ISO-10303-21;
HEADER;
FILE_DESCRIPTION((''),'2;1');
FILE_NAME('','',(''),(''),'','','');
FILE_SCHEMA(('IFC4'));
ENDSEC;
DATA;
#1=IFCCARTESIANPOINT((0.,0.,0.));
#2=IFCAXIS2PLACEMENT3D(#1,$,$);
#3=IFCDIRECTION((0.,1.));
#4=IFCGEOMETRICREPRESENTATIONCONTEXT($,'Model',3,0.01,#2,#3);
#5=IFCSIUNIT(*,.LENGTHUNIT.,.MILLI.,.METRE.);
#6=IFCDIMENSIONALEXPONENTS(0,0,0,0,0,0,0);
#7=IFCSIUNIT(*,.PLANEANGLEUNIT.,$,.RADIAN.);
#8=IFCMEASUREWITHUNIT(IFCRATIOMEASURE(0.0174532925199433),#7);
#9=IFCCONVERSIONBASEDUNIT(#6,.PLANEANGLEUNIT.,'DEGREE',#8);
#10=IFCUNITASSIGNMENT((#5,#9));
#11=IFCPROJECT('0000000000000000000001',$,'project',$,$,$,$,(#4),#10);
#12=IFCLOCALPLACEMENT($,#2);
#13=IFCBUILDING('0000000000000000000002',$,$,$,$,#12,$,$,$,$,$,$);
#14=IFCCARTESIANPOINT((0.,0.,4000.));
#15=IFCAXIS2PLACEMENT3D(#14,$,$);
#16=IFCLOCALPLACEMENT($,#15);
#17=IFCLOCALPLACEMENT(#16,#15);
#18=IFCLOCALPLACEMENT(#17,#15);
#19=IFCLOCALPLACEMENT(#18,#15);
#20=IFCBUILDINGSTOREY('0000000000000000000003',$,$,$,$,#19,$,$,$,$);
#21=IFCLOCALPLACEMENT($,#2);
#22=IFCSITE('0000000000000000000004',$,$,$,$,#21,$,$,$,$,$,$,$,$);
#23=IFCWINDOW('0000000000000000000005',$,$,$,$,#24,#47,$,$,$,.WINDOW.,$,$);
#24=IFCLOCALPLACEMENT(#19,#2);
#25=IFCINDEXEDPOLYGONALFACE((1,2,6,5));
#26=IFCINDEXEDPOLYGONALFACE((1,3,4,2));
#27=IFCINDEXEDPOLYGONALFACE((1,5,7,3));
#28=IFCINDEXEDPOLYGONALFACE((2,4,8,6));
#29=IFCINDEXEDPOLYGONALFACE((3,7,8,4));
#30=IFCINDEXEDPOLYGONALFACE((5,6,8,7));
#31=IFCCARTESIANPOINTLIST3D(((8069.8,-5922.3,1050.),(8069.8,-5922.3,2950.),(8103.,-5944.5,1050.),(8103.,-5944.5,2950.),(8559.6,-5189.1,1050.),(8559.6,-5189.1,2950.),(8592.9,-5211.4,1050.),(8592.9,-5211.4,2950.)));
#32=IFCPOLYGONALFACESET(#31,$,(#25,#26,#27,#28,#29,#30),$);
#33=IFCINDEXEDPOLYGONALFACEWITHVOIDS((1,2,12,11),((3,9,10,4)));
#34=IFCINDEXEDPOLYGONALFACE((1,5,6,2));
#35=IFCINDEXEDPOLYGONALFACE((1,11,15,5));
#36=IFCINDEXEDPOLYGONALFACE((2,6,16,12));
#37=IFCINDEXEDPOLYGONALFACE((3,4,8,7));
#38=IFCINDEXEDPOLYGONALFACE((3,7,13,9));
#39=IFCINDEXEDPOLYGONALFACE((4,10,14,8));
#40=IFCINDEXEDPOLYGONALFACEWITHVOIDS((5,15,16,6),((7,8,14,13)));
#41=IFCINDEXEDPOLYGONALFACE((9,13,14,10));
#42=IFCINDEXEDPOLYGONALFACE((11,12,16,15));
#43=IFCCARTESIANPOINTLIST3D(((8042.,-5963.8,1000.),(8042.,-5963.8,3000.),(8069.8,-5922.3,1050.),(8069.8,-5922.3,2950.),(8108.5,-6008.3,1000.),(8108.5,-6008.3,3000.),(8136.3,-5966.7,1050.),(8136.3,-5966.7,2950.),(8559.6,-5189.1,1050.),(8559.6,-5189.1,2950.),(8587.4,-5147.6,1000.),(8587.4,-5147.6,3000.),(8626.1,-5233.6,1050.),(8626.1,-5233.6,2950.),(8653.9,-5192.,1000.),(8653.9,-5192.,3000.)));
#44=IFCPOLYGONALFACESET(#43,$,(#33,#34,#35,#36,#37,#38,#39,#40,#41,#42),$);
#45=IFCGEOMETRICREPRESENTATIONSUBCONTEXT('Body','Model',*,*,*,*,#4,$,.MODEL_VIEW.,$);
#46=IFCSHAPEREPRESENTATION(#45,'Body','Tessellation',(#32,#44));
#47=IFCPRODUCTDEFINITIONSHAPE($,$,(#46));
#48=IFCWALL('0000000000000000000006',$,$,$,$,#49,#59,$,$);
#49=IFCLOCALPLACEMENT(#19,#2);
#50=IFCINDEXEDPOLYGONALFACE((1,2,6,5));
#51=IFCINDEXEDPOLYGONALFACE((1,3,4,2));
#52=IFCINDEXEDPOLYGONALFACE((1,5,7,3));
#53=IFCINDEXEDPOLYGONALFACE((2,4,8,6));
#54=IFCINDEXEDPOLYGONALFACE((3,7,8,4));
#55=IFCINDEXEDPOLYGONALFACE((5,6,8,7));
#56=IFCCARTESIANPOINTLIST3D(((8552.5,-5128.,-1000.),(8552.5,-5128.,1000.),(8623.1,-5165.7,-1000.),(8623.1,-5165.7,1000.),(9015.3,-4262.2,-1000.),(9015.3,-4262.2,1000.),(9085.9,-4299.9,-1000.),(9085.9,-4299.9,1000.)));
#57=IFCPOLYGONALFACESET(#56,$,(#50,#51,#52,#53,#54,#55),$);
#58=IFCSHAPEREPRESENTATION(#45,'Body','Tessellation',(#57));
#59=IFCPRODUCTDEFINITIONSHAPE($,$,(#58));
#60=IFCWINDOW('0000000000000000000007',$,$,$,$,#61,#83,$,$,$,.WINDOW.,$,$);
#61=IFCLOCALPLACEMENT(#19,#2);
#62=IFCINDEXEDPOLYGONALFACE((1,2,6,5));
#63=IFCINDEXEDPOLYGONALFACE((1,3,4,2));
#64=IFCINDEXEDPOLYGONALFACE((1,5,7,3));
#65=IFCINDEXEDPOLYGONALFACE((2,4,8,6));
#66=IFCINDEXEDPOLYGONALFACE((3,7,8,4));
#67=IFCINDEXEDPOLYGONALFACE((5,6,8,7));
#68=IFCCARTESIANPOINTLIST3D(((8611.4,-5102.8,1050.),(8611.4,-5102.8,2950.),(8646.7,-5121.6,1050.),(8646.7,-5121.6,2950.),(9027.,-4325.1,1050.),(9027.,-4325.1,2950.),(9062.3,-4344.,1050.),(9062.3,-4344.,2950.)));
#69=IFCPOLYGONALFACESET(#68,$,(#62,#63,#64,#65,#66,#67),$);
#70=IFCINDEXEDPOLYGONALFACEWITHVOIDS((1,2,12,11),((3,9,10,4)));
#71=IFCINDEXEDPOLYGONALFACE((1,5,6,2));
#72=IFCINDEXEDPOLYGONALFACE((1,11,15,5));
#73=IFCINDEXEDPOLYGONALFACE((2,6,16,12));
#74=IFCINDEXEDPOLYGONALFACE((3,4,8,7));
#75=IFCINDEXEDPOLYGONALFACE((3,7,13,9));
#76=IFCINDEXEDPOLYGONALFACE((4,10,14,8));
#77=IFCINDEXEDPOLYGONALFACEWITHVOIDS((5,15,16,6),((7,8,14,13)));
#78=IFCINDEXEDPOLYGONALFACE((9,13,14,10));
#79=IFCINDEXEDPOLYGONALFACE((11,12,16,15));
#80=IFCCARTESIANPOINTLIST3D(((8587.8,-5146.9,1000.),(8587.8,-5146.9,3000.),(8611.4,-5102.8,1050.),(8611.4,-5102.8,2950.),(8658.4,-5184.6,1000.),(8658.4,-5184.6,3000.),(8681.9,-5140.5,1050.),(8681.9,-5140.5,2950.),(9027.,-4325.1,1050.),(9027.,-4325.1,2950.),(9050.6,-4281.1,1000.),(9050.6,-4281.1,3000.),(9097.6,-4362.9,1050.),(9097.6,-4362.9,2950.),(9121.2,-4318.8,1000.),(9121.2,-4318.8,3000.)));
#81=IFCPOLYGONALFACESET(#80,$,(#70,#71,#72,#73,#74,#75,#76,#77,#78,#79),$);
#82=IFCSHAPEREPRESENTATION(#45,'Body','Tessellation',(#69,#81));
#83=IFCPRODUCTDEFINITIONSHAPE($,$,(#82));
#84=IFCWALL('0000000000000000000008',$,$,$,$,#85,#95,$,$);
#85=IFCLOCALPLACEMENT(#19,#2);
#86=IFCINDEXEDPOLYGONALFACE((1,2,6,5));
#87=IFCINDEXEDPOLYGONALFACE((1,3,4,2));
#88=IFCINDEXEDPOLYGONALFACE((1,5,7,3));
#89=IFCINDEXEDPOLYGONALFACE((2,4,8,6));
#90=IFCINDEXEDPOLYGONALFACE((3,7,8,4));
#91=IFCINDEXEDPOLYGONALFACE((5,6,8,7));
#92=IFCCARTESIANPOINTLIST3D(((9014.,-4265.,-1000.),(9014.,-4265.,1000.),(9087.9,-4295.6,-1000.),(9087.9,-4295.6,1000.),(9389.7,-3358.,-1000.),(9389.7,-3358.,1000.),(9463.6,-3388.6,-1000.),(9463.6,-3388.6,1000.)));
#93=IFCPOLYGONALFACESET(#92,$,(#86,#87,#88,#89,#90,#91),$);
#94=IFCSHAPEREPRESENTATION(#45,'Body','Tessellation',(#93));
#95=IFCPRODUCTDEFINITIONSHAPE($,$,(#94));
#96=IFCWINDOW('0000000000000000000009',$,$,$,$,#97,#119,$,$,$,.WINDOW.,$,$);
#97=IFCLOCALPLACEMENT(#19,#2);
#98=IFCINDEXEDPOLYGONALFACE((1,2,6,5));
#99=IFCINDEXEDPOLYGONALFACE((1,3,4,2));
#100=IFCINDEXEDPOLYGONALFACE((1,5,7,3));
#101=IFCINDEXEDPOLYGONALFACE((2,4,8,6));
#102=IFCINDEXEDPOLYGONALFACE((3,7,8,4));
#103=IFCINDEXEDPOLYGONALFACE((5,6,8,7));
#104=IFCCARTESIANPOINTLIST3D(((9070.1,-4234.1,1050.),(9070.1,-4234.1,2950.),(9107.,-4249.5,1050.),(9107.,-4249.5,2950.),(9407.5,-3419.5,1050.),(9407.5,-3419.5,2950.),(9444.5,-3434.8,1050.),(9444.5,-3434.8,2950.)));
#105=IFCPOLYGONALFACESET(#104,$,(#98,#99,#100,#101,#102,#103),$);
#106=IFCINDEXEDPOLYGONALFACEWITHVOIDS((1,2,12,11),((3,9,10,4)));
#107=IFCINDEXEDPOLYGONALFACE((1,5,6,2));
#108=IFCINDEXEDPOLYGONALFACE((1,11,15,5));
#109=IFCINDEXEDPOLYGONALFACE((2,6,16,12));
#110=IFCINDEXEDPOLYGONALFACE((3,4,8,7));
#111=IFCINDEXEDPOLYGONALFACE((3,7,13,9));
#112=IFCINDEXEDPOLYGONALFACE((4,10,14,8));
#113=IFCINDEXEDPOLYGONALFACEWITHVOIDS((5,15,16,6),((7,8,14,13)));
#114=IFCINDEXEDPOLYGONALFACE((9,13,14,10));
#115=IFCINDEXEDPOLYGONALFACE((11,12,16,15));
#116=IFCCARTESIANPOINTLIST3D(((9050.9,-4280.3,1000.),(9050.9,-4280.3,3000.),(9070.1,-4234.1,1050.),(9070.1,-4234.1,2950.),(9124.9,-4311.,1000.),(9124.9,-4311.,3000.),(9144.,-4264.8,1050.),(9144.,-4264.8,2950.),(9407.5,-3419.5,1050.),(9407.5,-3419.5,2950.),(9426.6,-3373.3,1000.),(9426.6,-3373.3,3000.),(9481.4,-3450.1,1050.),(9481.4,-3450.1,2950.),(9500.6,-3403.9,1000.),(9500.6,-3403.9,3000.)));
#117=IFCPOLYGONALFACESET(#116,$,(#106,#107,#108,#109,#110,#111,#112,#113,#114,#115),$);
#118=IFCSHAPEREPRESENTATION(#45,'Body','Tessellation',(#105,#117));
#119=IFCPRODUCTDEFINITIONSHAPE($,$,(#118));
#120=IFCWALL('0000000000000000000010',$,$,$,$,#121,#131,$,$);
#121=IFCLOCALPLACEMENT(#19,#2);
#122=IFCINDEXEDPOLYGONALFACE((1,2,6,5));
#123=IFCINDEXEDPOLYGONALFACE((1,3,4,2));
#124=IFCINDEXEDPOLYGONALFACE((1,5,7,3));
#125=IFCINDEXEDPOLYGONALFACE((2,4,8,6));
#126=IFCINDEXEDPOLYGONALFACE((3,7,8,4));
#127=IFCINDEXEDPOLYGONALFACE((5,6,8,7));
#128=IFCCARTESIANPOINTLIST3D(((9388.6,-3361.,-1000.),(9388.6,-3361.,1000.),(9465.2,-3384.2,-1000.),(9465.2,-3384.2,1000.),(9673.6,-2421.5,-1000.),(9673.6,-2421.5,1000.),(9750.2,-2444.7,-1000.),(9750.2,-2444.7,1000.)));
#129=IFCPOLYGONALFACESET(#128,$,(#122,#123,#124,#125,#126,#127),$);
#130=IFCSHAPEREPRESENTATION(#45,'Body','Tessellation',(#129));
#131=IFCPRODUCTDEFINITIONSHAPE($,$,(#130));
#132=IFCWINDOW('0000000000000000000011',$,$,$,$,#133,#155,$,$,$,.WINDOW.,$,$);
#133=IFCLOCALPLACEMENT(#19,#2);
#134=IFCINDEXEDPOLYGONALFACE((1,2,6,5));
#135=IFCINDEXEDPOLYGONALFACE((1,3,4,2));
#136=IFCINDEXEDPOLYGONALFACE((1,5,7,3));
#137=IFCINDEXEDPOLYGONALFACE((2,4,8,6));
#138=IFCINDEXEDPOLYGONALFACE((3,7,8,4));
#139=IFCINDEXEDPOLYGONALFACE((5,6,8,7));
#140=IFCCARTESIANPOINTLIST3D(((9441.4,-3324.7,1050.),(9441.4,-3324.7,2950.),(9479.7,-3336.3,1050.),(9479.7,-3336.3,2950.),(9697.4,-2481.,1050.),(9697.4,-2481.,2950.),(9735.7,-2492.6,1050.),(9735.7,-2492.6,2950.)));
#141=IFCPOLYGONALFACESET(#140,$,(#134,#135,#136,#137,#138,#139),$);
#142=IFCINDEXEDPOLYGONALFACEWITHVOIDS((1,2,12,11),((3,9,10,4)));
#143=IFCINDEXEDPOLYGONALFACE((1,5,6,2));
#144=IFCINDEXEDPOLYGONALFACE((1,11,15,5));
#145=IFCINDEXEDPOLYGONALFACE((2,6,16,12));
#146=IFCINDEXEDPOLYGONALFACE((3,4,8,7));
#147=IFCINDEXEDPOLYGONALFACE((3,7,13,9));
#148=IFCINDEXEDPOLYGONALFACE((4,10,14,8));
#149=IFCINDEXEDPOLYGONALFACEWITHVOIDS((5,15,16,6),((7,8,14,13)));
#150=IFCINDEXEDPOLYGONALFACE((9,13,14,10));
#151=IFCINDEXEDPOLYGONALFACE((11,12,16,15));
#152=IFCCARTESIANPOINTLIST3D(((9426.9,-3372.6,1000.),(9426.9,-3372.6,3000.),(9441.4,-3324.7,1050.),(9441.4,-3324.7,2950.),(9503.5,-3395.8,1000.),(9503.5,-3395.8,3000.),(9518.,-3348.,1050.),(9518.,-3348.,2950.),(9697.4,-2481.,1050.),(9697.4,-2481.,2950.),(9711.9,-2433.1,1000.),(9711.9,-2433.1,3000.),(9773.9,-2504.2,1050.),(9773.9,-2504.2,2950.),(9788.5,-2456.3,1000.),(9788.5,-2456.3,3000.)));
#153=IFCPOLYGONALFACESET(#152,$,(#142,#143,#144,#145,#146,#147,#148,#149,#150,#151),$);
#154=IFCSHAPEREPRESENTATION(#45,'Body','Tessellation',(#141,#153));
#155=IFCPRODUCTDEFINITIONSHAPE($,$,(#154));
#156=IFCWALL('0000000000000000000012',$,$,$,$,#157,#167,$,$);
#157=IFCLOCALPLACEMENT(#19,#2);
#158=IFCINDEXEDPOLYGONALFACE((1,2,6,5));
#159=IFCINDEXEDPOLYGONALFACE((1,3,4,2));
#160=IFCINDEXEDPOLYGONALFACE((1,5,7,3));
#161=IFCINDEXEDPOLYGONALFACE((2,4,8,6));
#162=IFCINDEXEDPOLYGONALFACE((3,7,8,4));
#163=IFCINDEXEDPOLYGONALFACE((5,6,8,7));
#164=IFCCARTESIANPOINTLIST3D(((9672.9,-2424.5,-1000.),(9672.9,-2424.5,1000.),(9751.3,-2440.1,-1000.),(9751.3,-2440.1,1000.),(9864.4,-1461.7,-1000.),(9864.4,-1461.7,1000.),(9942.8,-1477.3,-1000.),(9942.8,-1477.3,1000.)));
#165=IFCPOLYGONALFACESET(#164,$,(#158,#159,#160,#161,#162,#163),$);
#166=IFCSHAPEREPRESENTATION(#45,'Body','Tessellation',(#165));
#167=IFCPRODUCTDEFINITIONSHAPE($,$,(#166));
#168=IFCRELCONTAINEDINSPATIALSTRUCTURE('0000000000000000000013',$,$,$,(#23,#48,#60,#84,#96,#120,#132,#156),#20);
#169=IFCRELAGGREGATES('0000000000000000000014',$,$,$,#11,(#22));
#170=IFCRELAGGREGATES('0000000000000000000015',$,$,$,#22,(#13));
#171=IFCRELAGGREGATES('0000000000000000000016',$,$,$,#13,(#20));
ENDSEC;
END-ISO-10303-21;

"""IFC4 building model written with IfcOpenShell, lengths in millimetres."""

from ifc_helpers import new_model, entity, si_unit, converted_unit, direction, frame, origin, origin_2d, place, context, subcontext, project, spatial, rectangle, extrude, element, save


model = new_model("IFC4")

# Units and contexts
model_context = context("Model", 3, precision=0.01, world=origin(), true_north=direction((0.0, 1.0)))
body_context = subcontext(model_context, "Body", "Model", "MODEL_VIEW")
ifc_project = project(units=[si_unit("LENGTHUNIT", "METRE", prefix="MILLI"), converted_unit("PLANEANGLEUNIT", "DEGREE", entity("IfcRatioMeasure", 0.0174532925199433), si_unit("PLANEANGLEUNIT", "RADIAN"), dimensions=[0, 0, 0, 0, 0, 0, 0])], contexts=[model_context])

# Site, building, storey
site_placement = place(None, origin())
site = spatial("IfcSite", under=ifc_project, at=site_placement)
building_placement = place(None, origin())
building = spatial("IfcBuilding", under=site, at=building_placement)
placement_1 = place(None, frame((0.0, 0.0, 4000.0)))
placement_2 = place(placement_1, frame((0.0, 0.0, 4000.0)))
placement_3 = place(placement_2, frame((0.0, 0.0, 4000.0)))
storey_placement = place(placement_3, frame((0.0, 0.0, 4000.0)))
storey = spatial("IfcBuildingStorey", under=building, at=storey_placement)

# Shared definitions
cartesian_point_1 = entity("IfcCartesianPoint", [-440.9, -950.0])
shared_polyline = entity("IfcPolyline", [cartesian_point_1, entity("IfcCartesianPoint", [-440.9, 950.0]), entity("IfcCartesianPoint", [-440.9, 950.0]), entity("IfcCartesianPoint", [440.9, 950.0]), entity("IfcCartesianPoint", [440.9, 950.0]), entity("IfcCartesianPoint", [440.9, -950.0]), entity("IfcCartesianPoint", [440.9, -950.0]), entity("IfcCartesianPoint", [-440.9, -950.0]), cartesian_point_1])

# Window
window_1_placement = place(storey_placement, frame((8314.7, -5555.7, 2000.0), z_axis=(0.0, 0.0, 1.0), x_axis=(5555.702871, 8314.695762, 0.0)))
cartesian_point_2 = entity("IfcCartesianPoint", [-490.9, -1000.0])
element("IfcWindow", 1, at=window_1_placement, inside=storey, PredefinedType="WINDOW", context=body_context, shape_type="SweptSolid", body=[
    entity("IfcExtrudedAreaSolid", entity("IfcArbitraryClosedProfileDef", "AREA", None, shared_polyline), entity("IfcAxis2Placement3D", entity("IfcCartesianPoint", [0.0, 0.0, 0.0]), entity("IfcDirection", [0.0, -1.0, 0.0]), entity("IfcDirection", [1.0, 0.0, 0.0])), entity("IfcDirection", [0.0, 0.0, 1.0]), 40.0),
    entity("IfcExtrudedAreaSolid", entity("IfcArbitraryProfileDefWithVoids", "AREA", None, entity("IfcPolyline", [cartesian_point_2, entity("IfcCartesianPoint", [-490.9, 1000.0]), entity("IfcCartesianPoint", [-490.9, 1000.0]), entity("IfcCartesianPoint", [490.9, 1000.0]), entity("IfcCartesianPoint", [490.9, 1000.0]), entity("IfcCartesianPoint", [490.9, -1000.0]), entity("IfcCartesianPoint", [490.9, -1000.0]), entity("IfcCartesianPoint", [-490.9, -1000.0]), cartesian_point_2]), [shared_polyline]), entity("IfcAxis2Placement3D", entity("IfcCartesianPoint", [0.0, 0.0, 0.0]), entity("IfcDirection", [0.0, -1.0, 0.0]), entity("IfcDirection", [1.0, 0.0, 0.0])), entity("IfcDirection", [0.0, 0.0, 1.0]), 80.0),
])

# Wall
wall_1_placement = place(storey_placement, frame((8819.2, -4714.0, -1000.0), z_axis=(0.0, 0.0, 1.0), x_axis=(4713.965487, 8819.213649, 0.0)))
element("IfcWall", 2, at=wall_1_placement, inside=storey, context=body_context, shape_type="SweptSolid", body=[
    extrude(rectangle(XDim=981.7, YDim=80.0, at=origin_2d()), origin(), (0.0, 0.0, 1.0), 2000.0),
])

# Window
window_2_placement = place(storey_placement, frame((8819.2, -4714.0, 2000.0), z_axis=(0.0, 0.0, 1.0), x_axis=(4713.965487, 8819.213649, 0.0)))
cartesian_point_3 = entity("IfcCartesianPoint", [-490.9, -1000.0])
element("IfcWindow", 3, at=window_2_placement, inside=storey, PredefinedType="WINDOW", context=body_context, shape_type="SweptSolid", body=[
    entity("IfcExtrudedAreaSolid", entity("IfcArbitraryClosedProfileDef", "AREA", None, shared_polyline), entity("IfcAxis2Placement3D", entity("IfcCartesianPoint", [0.0, 0.0, 0.0]), entity("IfcDirection", [0.0, -1.0, 0.0]), entity("IfcDirection", [1.0, 0.0, 0.0])), entity("IfcDirection", [0.0, 0.0, 1.0]), 40.0),
    entity("IfcExtrudedAreaSolid", entity("IfcArbitraryProfileDefWithVoids", "AREA", None, entity("IfcPolyline", [cartesian_point_3, entity("IfcCartesianPoint", [-490.9, 1000.0]), entity("IfcCartesianPoint", [-490.9, 1000.0]), entity("IfcCartesianPoint", [490.9, 1000.0]), entity("IfcCartesianPoint", [490.9, 1000.0]), entity("IfcCartesianPoint", [490.9, -1000.0]), entity("IfcCartesianPoint", [490.9, -1000.0]), entity("IfcCartesianPoint", [-490.9, -1000.0]), cartesian_point_3]), [shared_polyline]), entity("IfcAxis2Placement3D", entity("IfcCartesianPoint", [0.0, 0.0, 0.0]), entity("IfcDirection", [0.0, -1.0, 0.0]), entity("IfcDirection", [1.0, 0.0, 0.0])), entity("IfcDirection", [0.0, 0.0, 1.0]), 80.0),
])

# Wall
wall_2_placement = place(storey_placement, frame((9238.8, -3826.8, -1000.0), z_axis=(0.0, 0.0, 1.0), x_axis=(3826.834186, 9238.795382, 0.0)))
element("IfcWall", 4, at=wall_2_placement, inside=storey, context=body_context, shape_type="SweptSolid", body=[
    extrude(rectangle(XDim=981.7, YDim=80.0, at=origin_2d()), origin(), (0.0, 0.0, 1.0), 2000.0),
])

# Window
window_3_placement = place(storey_placement, frame((9238.8, -3826.8, 2000.0), z_axis=(0.0, 0.0, 1.0), x_axis=(3826.834186, 9238.795382, 0.0)))
cartesian_point_4 = entity("IfcCartesianPoint", [-490.9, -1000.0])
element("IfcWindow", 5, at=window_3_placement, inside=storey, PredefinedType="WINDOW", context=body_context, shape_type="SweptSolid", body=[
    entity("IfcExtrudedAreaSolid", entity("IfcArbitraryClosedProfileDef", "AREA", None, shared_polyline), entity("IfcAxis2Placement3D", entity("IfcCartesianPoint", [0.0, 0.0, 0.0]), entity("IfcDirection", [0.0, -1.0, 0.0]), entity("IfcDirection", [1.0, 0.0, 0.0])), entity("IfcDirection", [0.0, 0.0, 1.0]), 40.0),
    entity("IfcExtrudedAreaSolid", entity("IfcArbitraryProfileDefWithVoids", "AREA", None, entity("IfcPolyline", [cartesian_point_4, entity("IfcCartesianPoint", [-490.9, 1000.0]), entity("IfcCartesianPoint", [-490.9, 1000.0]), entity("IfcCartesianPoint", [490.9, 1000.0]), entity("IfcCartesianPoint", [490.9, 1000.0]), entity("IfcCartesianPoint", [490.9, -1000.0]), entity("IfcCartesianPoint", [490.9, -1000.0]), entity("IfcCartesianPoint", [-490.9, -1000.0]), cartesian_point_4]), [shared_polyline]), entity("IfcAxis2Placement3D", entity("IfcCartesianPoint", [0.0, 0.0, 0.0]), entity("IfcDirection", [0.0, -1.0, 0.0]), entity("IfcDirection", [1.0, 0.0, 0.0])), entity("IfcDirection", [0.0, 0.0, 1.0]), 80.0),
])

# Wall
wall_3_placement = place(storey_placement, frame((9569.4, -2902.8, -1000.0), z_axis=(0.0, 0.0, 1.0), x_axis=(2902.848529, 9569.402825, 0.0)))
element("IfcWall", 6, at=wall_3_placement, inside=storey, context=body_context, shape_type="SweptSolid", body=[
    extrude(rectangle(XDim=981.7, YDim=80.0, at=origin_2d()), origin(), (0.0, 0.0, 1.0), 2000.0),
])

# Window
window_4_placement = place(storey_placement, frame((9569.4, -2902.8, 2000.0), z_axis=(0.0, 0.0, 1.0), x_axis=(2902.848529, 9569.402825, 0.0)))
cartesian_point_5 = entity("IfcCartesianPoint", [-490.9, -1000.0])
element("IfcWindow", 7, at=window_4_placement, inside=storey, PredefinedType="WINDOW", context=body_context, shape_type="SweptSolid", body=[
    entity("IfcExtrudedAreaSolid", entity("IfcArbitraryClosedProfileDef", "AREA", None, shared_polyline), entity("IfcAxis2Placement3D", entity("IfcCartesianPoint", [0.0, 0.0, 0.0]), entity("IfcDirection", [0.0, -1.0, 0.0]), entity("IfcDirection", [1.0, 0.0, 0.0])), entity("IfcDirection", [0.0, 0.0, 1.0]), 40.0),
    entity("IfcExtrudedAreaSolid", entity("IfcArbitraryProfileDefWithVoids", "AREA", None, entity("IfcPolyline", [cartesian_point_5, entity("IfcCartesianPoint", [-490.9, 1000.0]), entity("IfcCartesianPoint", [-490.9, 1000.0]), entity("IfcCartesianPoint", [490.9, 1000.0]), entity("IfcCartesianPoint", [490.9, 1000.0]), entity("IfcCartesianPoint", [490.9, -1000.0]), entity("IfcCartesianPoint", [490.9, -1000.0]), entity("IfcCartesianPoint", [-490.9, -1000.0]), cartesian_point_5]), [shared_polyline]), entity("IfcAxis2Placement3D", entity("IfcCartesianPoint", [0.0, 0.0, 0.0]), entity("IfcDirection", [0.0, -1.0, 0.0]), entity("IfcDirection", [1.0, 0.0, 0.0])), entity("IfcDirection", [0.0, 0.0, 1.0]), 80.0),
])

# Wall
wall_4_placement = place(storey_placement, frame((9807.9, -1950.9, -1000.0), z_axis=(0.0, 0.0, 1.0), x_axis=(1950.90229, 9807.852989, 0.0)))
element("IfcWall", 8, at=wall_4_placement, inside=storey, context=body_context, shape_type="SweptSolid", body=[
    extrude(rectangle(XDim=981.7, YDim=80.0, at=origin_2d()), origin(), (0.0, 0.0, 1.0), 2000.0),
])

save(model, "model.ifc")
